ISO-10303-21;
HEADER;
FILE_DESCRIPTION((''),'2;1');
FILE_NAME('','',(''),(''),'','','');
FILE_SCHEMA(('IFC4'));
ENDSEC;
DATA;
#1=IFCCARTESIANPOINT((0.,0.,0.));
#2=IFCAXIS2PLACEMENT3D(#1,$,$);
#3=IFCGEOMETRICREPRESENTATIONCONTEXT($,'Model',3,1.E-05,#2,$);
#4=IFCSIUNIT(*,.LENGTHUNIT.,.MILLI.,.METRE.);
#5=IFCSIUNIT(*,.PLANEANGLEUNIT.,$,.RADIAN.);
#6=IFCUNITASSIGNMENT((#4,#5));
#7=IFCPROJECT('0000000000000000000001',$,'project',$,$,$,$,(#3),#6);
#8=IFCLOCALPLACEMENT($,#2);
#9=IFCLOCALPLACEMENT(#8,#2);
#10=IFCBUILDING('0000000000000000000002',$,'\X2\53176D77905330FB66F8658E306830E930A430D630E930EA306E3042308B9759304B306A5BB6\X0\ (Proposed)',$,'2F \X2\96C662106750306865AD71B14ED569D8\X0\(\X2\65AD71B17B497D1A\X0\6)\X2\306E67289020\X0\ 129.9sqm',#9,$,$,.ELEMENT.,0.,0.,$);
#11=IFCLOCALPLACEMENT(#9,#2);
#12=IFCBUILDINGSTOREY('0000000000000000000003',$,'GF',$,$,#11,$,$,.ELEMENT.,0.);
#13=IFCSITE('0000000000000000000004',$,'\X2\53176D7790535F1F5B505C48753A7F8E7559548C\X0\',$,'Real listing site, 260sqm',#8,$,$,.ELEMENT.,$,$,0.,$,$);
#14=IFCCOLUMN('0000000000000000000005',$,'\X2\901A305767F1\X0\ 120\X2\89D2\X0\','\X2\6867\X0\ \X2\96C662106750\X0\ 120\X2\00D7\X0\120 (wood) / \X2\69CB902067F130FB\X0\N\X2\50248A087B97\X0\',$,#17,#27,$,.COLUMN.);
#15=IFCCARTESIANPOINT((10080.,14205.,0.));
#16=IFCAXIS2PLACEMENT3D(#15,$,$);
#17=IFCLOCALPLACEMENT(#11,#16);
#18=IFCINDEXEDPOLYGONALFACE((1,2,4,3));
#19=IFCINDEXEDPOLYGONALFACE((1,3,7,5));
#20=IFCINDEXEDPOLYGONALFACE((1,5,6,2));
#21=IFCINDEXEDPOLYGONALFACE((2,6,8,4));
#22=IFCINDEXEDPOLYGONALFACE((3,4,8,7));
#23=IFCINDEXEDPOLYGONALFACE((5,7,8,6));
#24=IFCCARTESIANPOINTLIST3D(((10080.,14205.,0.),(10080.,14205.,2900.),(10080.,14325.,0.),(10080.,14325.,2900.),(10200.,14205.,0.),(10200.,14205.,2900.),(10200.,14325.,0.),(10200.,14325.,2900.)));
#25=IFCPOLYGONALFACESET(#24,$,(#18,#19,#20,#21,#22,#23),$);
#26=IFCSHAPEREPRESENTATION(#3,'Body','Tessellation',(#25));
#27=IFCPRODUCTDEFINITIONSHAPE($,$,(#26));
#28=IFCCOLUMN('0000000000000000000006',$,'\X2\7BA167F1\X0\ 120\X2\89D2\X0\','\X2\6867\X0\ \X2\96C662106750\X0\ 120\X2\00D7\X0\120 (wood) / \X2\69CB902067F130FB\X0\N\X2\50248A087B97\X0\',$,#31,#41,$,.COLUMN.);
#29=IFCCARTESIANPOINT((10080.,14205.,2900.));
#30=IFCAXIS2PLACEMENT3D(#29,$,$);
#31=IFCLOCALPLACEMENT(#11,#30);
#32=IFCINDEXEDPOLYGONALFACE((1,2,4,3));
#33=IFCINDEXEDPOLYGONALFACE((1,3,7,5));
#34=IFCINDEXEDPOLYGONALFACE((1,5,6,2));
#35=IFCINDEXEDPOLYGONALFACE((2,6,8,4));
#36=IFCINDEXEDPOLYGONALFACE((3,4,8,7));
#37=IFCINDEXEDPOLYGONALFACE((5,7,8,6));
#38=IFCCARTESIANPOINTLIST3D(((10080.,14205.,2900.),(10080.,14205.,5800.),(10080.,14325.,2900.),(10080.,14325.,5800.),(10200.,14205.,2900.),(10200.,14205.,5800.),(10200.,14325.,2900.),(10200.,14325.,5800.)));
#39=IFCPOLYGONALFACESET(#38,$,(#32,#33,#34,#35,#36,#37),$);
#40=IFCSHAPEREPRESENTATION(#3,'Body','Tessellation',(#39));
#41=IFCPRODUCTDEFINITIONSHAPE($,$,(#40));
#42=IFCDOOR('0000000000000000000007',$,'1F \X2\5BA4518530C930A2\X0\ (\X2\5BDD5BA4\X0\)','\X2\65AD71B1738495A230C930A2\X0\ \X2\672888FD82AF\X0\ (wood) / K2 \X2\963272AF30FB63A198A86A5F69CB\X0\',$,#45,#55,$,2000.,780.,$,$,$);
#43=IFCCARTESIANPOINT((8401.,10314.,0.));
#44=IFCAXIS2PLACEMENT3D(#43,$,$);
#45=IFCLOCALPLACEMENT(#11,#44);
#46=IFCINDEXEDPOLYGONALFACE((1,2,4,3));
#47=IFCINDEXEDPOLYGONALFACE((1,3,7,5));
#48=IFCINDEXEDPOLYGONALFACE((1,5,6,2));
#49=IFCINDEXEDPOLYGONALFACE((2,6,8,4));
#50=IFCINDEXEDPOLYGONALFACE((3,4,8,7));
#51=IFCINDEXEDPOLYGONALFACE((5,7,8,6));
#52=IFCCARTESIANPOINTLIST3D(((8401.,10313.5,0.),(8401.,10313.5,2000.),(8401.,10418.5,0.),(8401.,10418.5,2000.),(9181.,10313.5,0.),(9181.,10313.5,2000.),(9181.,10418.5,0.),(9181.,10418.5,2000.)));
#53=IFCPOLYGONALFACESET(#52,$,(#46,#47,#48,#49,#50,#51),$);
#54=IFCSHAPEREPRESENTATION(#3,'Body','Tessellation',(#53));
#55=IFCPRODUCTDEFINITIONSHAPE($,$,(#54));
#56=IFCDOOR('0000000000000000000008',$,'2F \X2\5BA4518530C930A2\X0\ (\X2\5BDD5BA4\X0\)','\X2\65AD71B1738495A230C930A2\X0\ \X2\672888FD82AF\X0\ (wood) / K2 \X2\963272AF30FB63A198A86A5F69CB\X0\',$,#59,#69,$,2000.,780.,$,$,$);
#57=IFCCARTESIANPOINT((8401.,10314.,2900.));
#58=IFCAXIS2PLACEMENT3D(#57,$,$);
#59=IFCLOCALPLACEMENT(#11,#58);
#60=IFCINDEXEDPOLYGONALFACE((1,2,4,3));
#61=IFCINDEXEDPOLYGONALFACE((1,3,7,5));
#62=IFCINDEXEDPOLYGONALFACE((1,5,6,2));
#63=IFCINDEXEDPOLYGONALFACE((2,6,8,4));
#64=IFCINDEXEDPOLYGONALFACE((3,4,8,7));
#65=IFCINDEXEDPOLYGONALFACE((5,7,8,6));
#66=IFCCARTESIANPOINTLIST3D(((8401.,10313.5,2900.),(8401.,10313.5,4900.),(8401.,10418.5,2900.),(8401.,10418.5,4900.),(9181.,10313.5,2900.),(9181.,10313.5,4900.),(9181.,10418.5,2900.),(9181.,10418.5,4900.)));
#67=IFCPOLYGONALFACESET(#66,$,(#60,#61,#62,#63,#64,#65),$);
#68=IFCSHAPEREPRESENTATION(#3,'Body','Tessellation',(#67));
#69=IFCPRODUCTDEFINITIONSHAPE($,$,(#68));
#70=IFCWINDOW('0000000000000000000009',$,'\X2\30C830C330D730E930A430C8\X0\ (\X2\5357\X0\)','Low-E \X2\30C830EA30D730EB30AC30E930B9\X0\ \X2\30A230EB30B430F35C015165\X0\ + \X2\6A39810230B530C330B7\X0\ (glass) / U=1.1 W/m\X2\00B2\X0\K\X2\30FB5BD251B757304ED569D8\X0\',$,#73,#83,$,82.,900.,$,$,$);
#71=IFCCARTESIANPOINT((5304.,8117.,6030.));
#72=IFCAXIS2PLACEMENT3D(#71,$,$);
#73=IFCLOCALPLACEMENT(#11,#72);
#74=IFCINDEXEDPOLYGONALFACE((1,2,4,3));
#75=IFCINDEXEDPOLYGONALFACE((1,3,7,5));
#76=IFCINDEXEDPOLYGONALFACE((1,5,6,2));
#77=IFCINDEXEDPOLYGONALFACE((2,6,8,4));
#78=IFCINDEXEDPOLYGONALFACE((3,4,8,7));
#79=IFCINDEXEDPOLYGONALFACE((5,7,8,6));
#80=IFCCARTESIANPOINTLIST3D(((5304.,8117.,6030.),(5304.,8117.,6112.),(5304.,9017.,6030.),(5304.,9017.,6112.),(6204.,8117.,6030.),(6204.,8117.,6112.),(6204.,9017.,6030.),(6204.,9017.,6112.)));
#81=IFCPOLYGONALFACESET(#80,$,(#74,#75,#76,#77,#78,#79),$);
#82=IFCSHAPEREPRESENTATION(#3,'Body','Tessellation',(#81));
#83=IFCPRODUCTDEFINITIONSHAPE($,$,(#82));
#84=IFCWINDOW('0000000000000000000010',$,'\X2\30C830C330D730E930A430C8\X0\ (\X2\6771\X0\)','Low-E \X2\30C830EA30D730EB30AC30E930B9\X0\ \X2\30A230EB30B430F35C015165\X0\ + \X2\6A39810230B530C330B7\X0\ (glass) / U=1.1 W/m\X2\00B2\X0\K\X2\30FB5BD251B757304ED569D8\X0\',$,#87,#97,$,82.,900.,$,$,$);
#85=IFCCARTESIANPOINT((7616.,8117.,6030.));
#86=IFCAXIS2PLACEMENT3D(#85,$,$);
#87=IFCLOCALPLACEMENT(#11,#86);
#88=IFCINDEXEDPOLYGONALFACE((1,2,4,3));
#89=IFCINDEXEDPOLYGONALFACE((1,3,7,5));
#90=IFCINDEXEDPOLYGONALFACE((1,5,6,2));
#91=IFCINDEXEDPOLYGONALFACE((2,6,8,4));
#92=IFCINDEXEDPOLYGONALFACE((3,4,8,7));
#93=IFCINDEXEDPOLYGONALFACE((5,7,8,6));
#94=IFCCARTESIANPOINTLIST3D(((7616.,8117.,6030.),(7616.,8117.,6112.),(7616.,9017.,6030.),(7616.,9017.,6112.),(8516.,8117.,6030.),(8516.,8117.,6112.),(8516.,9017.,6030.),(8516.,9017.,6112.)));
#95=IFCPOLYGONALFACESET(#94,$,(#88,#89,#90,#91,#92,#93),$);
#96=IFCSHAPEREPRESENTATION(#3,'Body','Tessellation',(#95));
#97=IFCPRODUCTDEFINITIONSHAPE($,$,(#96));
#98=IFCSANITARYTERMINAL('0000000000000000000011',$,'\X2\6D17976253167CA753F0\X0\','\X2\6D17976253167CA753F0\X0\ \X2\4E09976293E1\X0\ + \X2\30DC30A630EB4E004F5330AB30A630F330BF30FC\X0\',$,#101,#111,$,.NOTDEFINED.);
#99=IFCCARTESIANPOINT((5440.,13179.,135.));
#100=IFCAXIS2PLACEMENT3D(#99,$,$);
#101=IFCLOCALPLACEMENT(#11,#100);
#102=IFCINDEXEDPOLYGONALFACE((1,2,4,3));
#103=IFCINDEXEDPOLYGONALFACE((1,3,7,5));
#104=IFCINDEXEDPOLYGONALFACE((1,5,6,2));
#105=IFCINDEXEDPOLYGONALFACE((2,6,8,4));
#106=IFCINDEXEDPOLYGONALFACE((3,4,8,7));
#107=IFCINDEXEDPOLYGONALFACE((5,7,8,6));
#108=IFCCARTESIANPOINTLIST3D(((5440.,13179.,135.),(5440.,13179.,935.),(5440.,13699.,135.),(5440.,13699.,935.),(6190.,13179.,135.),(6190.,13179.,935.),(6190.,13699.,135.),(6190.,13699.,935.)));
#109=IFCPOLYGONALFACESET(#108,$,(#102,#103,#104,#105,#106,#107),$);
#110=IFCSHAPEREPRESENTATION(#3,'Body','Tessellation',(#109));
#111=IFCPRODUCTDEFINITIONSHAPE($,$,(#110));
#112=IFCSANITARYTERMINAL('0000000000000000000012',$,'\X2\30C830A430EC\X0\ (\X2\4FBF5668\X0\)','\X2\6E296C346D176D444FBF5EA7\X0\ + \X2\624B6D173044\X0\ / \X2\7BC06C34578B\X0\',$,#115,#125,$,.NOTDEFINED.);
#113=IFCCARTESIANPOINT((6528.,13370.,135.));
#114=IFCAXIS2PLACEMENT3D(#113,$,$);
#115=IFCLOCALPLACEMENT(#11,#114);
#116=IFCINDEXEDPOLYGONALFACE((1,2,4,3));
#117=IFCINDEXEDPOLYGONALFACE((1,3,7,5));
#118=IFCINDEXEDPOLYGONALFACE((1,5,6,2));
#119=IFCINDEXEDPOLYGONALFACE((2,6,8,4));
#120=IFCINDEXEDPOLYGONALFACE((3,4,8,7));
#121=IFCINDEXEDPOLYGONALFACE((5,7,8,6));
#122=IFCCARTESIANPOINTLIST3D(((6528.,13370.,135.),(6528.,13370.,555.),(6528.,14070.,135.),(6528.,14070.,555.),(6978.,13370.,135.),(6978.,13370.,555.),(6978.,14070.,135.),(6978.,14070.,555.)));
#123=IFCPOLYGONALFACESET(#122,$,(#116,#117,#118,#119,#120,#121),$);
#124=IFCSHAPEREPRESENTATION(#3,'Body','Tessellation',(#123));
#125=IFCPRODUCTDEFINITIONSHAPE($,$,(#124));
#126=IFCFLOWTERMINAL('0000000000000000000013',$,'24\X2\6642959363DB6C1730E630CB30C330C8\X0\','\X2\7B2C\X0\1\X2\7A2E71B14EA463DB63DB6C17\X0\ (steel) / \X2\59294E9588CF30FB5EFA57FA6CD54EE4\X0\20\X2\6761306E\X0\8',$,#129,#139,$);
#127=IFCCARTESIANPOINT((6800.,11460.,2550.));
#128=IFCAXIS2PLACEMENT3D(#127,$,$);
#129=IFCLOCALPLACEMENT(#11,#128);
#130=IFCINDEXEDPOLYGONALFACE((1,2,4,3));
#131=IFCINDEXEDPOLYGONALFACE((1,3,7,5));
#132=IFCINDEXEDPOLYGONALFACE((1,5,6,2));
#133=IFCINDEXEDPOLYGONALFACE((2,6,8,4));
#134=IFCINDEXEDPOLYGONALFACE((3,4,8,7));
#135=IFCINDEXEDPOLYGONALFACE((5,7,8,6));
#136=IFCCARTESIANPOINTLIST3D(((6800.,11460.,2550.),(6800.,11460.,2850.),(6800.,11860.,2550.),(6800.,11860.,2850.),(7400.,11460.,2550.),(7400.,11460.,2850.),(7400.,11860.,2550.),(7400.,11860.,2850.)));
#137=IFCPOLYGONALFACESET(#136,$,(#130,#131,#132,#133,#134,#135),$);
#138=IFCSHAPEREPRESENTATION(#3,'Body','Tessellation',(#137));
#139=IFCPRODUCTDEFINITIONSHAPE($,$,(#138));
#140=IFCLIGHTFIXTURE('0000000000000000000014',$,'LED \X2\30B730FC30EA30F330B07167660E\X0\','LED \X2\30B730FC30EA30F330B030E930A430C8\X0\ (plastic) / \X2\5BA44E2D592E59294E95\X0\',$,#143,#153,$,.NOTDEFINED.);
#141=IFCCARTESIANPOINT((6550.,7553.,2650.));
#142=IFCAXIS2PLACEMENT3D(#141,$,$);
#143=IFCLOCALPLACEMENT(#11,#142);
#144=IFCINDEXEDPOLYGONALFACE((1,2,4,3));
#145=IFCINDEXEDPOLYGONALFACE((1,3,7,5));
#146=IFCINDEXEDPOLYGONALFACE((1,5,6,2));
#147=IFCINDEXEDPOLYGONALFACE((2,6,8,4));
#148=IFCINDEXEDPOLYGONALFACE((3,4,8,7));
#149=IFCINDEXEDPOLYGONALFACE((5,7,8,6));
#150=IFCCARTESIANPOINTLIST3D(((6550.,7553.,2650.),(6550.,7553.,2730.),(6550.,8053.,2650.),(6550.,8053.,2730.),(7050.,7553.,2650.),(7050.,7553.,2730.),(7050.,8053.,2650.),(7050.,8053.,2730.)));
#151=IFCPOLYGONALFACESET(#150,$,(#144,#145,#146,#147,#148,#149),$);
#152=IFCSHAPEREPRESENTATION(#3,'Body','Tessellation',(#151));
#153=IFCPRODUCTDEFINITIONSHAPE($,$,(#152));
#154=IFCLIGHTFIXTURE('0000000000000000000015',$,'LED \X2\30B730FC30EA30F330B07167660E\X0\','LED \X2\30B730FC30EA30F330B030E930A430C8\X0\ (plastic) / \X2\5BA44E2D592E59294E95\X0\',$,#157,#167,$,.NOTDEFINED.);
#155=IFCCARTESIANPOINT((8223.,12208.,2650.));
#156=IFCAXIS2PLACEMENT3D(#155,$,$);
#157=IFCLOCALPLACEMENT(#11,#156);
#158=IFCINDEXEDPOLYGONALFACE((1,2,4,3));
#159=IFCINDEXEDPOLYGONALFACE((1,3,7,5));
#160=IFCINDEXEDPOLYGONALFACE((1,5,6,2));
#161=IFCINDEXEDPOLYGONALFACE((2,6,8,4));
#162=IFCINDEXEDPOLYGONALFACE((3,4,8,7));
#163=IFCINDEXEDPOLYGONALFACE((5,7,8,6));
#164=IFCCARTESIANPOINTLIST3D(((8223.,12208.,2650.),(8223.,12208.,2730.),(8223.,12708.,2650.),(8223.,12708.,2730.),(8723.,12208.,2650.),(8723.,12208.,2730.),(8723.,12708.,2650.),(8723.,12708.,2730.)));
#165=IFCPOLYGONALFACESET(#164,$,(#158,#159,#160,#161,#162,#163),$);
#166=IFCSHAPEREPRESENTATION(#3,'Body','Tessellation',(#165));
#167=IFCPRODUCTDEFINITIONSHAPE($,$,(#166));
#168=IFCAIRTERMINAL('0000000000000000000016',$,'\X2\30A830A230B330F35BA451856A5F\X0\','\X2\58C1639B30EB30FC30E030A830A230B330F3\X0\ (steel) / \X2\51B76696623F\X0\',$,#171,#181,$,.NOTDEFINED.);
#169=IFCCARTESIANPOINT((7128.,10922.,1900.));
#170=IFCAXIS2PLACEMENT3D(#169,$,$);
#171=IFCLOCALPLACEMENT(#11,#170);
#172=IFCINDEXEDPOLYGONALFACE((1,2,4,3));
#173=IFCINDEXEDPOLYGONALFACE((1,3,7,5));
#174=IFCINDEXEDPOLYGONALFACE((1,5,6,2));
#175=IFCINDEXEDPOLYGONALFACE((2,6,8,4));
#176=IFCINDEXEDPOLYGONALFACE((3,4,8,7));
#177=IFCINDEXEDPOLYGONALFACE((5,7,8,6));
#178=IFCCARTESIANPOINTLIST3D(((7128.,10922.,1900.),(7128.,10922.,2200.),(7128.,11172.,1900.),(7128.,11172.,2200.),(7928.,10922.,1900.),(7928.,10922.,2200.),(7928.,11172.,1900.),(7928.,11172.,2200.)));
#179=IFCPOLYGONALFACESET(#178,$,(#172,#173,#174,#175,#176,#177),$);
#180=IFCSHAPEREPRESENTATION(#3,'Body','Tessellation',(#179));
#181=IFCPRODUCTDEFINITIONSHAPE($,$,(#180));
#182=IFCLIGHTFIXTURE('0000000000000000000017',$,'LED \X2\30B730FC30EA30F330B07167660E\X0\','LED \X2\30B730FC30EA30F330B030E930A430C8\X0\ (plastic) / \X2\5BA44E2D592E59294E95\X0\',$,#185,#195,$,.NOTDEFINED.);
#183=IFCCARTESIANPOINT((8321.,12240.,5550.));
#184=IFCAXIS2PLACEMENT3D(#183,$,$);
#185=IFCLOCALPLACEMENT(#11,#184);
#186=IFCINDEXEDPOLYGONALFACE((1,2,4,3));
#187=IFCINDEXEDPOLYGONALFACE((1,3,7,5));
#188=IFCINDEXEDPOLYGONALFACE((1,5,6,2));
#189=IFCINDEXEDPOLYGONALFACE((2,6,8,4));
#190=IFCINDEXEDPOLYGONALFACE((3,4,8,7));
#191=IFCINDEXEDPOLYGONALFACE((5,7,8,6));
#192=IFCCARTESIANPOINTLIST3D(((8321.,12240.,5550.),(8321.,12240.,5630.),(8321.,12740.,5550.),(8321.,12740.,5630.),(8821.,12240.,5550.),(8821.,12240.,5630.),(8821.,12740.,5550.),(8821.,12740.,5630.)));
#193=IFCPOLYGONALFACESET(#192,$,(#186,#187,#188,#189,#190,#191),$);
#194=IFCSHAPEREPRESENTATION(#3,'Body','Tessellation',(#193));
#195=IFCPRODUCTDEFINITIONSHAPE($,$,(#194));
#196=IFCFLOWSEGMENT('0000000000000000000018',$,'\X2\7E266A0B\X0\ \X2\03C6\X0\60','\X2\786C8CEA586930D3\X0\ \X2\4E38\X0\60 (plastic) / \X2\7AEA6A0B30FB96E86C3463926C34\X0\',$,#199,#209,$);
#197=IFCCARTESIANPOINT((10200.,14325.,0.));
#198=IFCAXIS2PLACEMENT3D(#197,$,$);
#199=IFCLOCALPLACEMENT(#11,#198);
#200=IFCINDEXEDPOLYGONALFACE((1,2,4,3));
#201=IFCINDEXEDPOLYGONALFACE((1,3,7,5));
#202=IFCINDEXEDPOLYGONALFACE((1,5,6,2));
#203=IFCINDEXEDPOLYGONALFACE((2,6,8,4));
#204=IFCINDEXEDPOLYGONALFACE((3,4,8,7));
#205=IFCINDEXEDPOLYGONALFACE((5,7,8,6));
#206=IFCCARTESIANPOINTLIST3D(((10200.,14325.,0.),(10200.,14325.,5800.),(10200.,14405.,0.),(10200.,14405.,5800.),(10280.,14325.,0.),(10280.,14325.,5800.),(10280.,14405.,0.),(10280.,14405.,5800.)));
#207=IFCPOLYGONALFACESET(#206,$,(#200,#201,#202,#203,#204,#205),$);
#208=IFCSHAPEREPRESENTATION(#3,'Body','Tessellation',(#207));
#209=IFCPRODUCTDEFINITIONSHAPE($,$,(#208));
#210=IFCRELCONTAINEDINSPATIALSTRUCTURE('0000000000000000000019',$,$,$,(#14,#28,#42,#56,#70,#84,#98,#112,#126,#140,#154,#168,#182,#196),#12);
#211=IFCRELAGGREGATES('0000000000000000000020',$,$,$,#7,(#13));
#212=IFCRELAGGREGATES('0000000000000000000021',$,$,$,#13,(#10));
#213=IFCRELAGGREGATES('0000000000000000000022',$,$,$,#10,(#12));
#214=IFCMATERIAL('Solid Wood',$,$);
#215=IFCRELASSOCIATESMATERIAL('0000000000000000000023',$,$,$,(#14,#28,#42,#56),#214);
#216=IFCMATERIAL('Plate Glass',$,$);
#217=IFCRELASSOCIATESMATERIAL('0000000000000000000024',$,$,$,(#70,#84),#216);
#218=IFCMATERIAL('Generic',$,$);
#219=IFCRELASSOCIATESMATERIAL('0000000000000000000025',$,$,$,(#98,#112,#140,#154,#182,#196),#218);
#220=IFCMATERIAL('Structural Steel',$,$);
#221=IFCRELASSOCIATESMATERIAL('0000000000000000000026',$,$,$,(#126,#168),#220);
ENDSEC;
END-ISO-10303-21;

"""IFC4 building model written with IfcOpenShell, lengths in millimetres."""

from ifc_helpers import new_model, si_unit, frame, frame_2d, origin, place, context, project, spatial, rectangle, extrude, material, element, save


model = new_model("IFC4")

# Units and contexts
model_context = context("Model", 3, precision=1e-05, world=origin())
ifc_project = project(units=[si_unit("LENGTHUNIT", "METRE", prefix="MILLI"), si_unit("PLANEANGLEUNIT", "RADIAN")], contexts=[model_context])

# Site, building, storey
site_placement = place(None, origin())
site = spatial("IfcSite", under=ifc_project, at=site_placement, Name="北海道弟子屈町美留和", ObjectType="Real listing site, 260sqm", CompositionType="ELEMENT", RefElevation=0.0)
building_placement = place(site_placement, origin())
building = spatial("IfcBuilding", under=site, at=building_placement, Name="北海道・書斎とライブラリのある静かな家 (Proposed)", ObjectType="2F 集成材と断熱仕様(断熱等級6)の木造 129.9sqm", CompositionType="ELEMENT", ElevationOfRefHeight=0.0, ElevationOfTerrain=0.0)
storey_placement = place(building_placement, origin())
storey = spatial("IfcBuildingStorey", under=building, at=storey_placement, Name="GF", CompositionType="ELEMENT", Elevation=0.0)

# Columns
ifc_material_1 = material(Name="Solid Wood")
column_1_placement = place(storey_placement, frame((10080.0, 14205.0, 0.0)))
element("IfcColumn", 1, at=column_1_placement, inside=storey, material=ifc_material_1, Name="通し柱 120角", Description="桧 集成材 120×120 (wood) / 構造柱・N値計算", PredefinedType="COLUMN", context=model_context, shape_type="SweptSolid", body=[
    extrude(rectangle(XDim=120.0, YDim=120.0, at=frame_2d((60.0, 60.0))), frame((10080.0, 14205.0, 0.0)), (0.0, 0.0, 1.0), 2900.0),
])
column_2_placement = place(storey_placement, frame((10080.0, 14205.0, 2900.0)))
element("IfcColumn", 2, at=column_2_placement, inside=storey, material=ifc_material_1, Name="管柱 120角", Description="桧 集成材 120×120 (wood) / 構造柱・N値計算", PredefinedType="COLUMN", context=model_context, shape_type="SweptSolid", body=[
    extrude(rectangle(XDim=120.0, YDim=120.0, at=frame_2d((60.0, 60.0))), frame((10080.0, 14205.0, 2900.0)), (0.0, 0.0, 1.0), 2900.0),
])

# Door
door_1_placement = place(storey_placement, frame((8401.0, 10314.0, 0.0)))
element("IfcDoor", 3, at=door_1_placement, inside=storey, material=ifc_material_1, Name="1F 室内ドア (寝室)", Description="断熱玄関ドア 木製芯 (wood) / K2 防犯・採風機構", OverallHeight=2000.0, OverallWidth=780.0, context=model_context, shape_type="SweptSolid", body=[
    extrude(rectangle(XDim=780.0, YDim=105.0, at=frame_2d((390.0, 52.0))), frame((8401.0, 10314.0, 0.0)), (0.0, 0.0, 1.0), 2000.0),
])

# Door
door_2_placement = place(storey_placement, frame((8401.0, 10314.0, 2900.0)))
element("IfcDoor", 4, at=door_2_placement, inside=storey, material=ifc_material_1, Name="2F 室内ドア (寝室)", Description="断熱玄関ドア 木製芯 (wood) / K2 防犯・採風機構", OverallHeight=2000.0, OverallWidth=780.0, context=model_context, shape_type="SweptSolid", body=[
    extrude(rectangle(XDim=780.0, YDim=105.0, at=frame_2d((390.0, 52.0))), frame((8401.0, 10314.0, 2900.0)), (0.0, 0.0, 1.0), 2000.0),
])

# Windows
ifc_material_2 = material(Name="Plate Glass")
window_1_placement = place(storey_placement, frame((5304.0, 8117.0, 6030.0)))
element("IfcWindow", 5, at=window_1_placement, inside=storey, material=ifc_material_2, Name="トップライト (南)", Description="Low-E トリプルガラス アルゴン封入 + 樹脂サッシ (glass) / U=1.1 W/m²K・寒冷地仕様", OverallHeight=82.0, OverallWidth=900.0, context=model_context, shape_type="SweptSolid", body=[
    extrude(rectangle(XDim=900.0, YDim=900.0, at=frame_2d((450.0, 450.0))), frame((5304.0, 8117.0, 6030.0)), (0.0, 0.0, 1.0), 82.0),
])
window_2_placement = place(storey_placement, frame((7616.0, 8117.0, 6030.0)))
element("IfcWindow", 6, at=window_2_placement, inside=storey, material=ifc_material_2, Name="トップライト (東)", Description="Low-E トリプルガラス アルゴン封入 + 樹脂サッシ (glass) / U=1.1 W/m²K・寒冷地仕様", OverallHeight=82.0, OverallWidth=900.0, context=model_context, shape_type="SweptSolid", body=[
    extrude(rectangle(XDim=900.0, YDim=900.0, at=frame_2d((450.0, 450.0))), frame((7616.0, 8117.0, 6030.0)), (0.0, 0.0, 1.0), 82.0),
])

# Sanitary terminals
ifc_material_3 = material(Name="Generic")
sanitary_terminal_1_placement = place(storey_placement, frame((5440.0, 13179.0, 135.0)))
element("IfcSanitaryTerminal", 7, at=sanitary_terminal_1_placement, inside=storey, material=ifc_material_3, Name="洗面化粧台", Description="洗面化粧台 三面鏡 + ボウル一体カウンター", PredefinedType="NOTDEFINED", context=model_context, shape_type="SweptSolid", body=[
    extrude(rectangle(XDim=750.0, YDim=520.0, at=frame_2d((375.0, 260.0))), frame((5440.0, 13179.0, 135.0)), (0.0, 0.0, 1.0), 800.0),
])
sanitary_terminal_2_placement = place(storey_placement, frame((6528.0, 13370.0, 135.0)))
element("IfcSanitaryTerminal", 8, at=sanitary_terminal_2_placement, inside=storey, material=ifc_material_3, Name="トイレ (便器)", Description="温水洗浄便座 + 手洗い / 節水型", PredefinedType="NOTDEFINED", context=model_context, shape_type="SweptSolid", body=[
    extrude(rectangle(XDim=450.0, YDim=700.0, at=frame_2d((225.0, 350.0))), frame((6528.0, 13370.0, 135.0)), (0.0, 0.0, 1.0), 420.0),
])

# Flow terminal
ifc_material_4 = material(Name="Structural Steel")
flow_terminal_placement = place(storey_placement, frame((6800.0, 11460.0, 2550.0)))
element("IfcFlowTerminal", 9, at=flow_terminal_placement, inside=storey, material=ifc_material_4, Name="24時間換気ユニット", Description="第1種熱交換換気 (steel) / 天井裏・建基法令20条の8", context=model_context, shape_type="SweptSolid", body=[
    extrude(rectangle(XDim=600.0, YDim=400.0, at=frame_2d((300.0, 200.0))), frame((6800.0, 11460.0, 2550.0)), (0.0, 0.0, 1.0), 300.0),
])

# Light fixtures
light_fixture_1_placement = place(storey_placement, frame((6550.0, 7553.0, 2650.0)))
element("IfcLightFixture", 10, at=light_fixture_1_placement, inside=storey, material=ifc_material_3, Name="LED シーリング照明", Description="LED シーリングライト (plastic) / 室中央天井", PredefinedType="NOTDEFINED", context=model_context, shape_type="SweptSolid", body=[
    extrude(rectangle(XDim=500.0, YDim=500.0, at=frame_2d((250.0, 250.0))), frame((6550.0, 7553.0, 2650.0)), (0.0, 0.0, 1.0), 80.0),
])
light_fixture_2_placement = place(storey_placement, frame((8223.0, 12208.0, 2650.0)))
element("IfcLightFixture", 11, at=light_fixture_2_placement, inside=storey, material=ifc_material_3, Name="LED シーリング照明", Description="LED シーリングライト (plastic) / 室中央天井", PredefinedType="NOTDEFINED", context=model_context, shape_type="SweptSolid", body=[
    extrude(rectangle(XDim=500.0, YDim=500.0, at=frame_2d((250.0, 250.0))), frame((8223.0, 12208.0, 2650.0)), (0.0, 0.0, 1.0), 80.0),
])

# Air terminal
air_terminal_placement = place(storey_placement, frame((7128.0, 10922.0, 1900.0)))
element("IfcAirTerminal", 12, at=air_terminal_placement, inside=storey, material=ifc_material_4, Name="エアコン室内機", Description="壁掛ルームエアコン (steel) / 冷暖房", PredefinedType="NOTDEFINED", context=model_context, shape_type="SweptSolid", body=[
    extrude(rectangle(XDim=800.0, YDim=250.0, at=frame_2d((400.0, 125.0))), frame((7128.0, 10922.0, 1900.0)), (0.0, 0.0, 1.0), 300.0),
])

# Light fixture
light_fixture_3_placement = place(storey_placement, frame((8321.0, 12240.0, 5550.0)))
element("IfcLightFixture", 13, at=light_fixture_3_placement, inside=storey, material=ifc_material_3, Name="LED シーリング照明", Description="LED シーリングライト (plastic) / 室中央天井", PredefinedType="NOTDEFINED", context=model_context, shape_type="SweptSolid", body=[
    extrude(rectangle(XDim=500.0, YDim=500.0, at=frame_2d((250.0, 250.0))), frame((8321.0, 12240.0, 5550.0)), (0.0, 0.0, 1.0), 80.0),
])

# Flow segment
flow_segment_placement = place(storey_placement, frame((10200.0, 14325.0, 0.0)))
element("IfcFlowSegment", 14, at=flow_segment_placement, inside=storey, material=ifc_material_3, Name="縦樋 φ60", Description="硬質塩ビ 丸60 (plastic) / 竪樋・雨水排水", context=model_context, shape_type="SweptSolid", body=[
    extrude(rectangle(XDim=80.0, YDim=80.0, at=frame_2d((40.0, 40.0))), frame((10200.0, 14325.0, 0.0)), (0.0, 0.0, 1.0), 5800.0),
])

save(model, "model.ifc")
